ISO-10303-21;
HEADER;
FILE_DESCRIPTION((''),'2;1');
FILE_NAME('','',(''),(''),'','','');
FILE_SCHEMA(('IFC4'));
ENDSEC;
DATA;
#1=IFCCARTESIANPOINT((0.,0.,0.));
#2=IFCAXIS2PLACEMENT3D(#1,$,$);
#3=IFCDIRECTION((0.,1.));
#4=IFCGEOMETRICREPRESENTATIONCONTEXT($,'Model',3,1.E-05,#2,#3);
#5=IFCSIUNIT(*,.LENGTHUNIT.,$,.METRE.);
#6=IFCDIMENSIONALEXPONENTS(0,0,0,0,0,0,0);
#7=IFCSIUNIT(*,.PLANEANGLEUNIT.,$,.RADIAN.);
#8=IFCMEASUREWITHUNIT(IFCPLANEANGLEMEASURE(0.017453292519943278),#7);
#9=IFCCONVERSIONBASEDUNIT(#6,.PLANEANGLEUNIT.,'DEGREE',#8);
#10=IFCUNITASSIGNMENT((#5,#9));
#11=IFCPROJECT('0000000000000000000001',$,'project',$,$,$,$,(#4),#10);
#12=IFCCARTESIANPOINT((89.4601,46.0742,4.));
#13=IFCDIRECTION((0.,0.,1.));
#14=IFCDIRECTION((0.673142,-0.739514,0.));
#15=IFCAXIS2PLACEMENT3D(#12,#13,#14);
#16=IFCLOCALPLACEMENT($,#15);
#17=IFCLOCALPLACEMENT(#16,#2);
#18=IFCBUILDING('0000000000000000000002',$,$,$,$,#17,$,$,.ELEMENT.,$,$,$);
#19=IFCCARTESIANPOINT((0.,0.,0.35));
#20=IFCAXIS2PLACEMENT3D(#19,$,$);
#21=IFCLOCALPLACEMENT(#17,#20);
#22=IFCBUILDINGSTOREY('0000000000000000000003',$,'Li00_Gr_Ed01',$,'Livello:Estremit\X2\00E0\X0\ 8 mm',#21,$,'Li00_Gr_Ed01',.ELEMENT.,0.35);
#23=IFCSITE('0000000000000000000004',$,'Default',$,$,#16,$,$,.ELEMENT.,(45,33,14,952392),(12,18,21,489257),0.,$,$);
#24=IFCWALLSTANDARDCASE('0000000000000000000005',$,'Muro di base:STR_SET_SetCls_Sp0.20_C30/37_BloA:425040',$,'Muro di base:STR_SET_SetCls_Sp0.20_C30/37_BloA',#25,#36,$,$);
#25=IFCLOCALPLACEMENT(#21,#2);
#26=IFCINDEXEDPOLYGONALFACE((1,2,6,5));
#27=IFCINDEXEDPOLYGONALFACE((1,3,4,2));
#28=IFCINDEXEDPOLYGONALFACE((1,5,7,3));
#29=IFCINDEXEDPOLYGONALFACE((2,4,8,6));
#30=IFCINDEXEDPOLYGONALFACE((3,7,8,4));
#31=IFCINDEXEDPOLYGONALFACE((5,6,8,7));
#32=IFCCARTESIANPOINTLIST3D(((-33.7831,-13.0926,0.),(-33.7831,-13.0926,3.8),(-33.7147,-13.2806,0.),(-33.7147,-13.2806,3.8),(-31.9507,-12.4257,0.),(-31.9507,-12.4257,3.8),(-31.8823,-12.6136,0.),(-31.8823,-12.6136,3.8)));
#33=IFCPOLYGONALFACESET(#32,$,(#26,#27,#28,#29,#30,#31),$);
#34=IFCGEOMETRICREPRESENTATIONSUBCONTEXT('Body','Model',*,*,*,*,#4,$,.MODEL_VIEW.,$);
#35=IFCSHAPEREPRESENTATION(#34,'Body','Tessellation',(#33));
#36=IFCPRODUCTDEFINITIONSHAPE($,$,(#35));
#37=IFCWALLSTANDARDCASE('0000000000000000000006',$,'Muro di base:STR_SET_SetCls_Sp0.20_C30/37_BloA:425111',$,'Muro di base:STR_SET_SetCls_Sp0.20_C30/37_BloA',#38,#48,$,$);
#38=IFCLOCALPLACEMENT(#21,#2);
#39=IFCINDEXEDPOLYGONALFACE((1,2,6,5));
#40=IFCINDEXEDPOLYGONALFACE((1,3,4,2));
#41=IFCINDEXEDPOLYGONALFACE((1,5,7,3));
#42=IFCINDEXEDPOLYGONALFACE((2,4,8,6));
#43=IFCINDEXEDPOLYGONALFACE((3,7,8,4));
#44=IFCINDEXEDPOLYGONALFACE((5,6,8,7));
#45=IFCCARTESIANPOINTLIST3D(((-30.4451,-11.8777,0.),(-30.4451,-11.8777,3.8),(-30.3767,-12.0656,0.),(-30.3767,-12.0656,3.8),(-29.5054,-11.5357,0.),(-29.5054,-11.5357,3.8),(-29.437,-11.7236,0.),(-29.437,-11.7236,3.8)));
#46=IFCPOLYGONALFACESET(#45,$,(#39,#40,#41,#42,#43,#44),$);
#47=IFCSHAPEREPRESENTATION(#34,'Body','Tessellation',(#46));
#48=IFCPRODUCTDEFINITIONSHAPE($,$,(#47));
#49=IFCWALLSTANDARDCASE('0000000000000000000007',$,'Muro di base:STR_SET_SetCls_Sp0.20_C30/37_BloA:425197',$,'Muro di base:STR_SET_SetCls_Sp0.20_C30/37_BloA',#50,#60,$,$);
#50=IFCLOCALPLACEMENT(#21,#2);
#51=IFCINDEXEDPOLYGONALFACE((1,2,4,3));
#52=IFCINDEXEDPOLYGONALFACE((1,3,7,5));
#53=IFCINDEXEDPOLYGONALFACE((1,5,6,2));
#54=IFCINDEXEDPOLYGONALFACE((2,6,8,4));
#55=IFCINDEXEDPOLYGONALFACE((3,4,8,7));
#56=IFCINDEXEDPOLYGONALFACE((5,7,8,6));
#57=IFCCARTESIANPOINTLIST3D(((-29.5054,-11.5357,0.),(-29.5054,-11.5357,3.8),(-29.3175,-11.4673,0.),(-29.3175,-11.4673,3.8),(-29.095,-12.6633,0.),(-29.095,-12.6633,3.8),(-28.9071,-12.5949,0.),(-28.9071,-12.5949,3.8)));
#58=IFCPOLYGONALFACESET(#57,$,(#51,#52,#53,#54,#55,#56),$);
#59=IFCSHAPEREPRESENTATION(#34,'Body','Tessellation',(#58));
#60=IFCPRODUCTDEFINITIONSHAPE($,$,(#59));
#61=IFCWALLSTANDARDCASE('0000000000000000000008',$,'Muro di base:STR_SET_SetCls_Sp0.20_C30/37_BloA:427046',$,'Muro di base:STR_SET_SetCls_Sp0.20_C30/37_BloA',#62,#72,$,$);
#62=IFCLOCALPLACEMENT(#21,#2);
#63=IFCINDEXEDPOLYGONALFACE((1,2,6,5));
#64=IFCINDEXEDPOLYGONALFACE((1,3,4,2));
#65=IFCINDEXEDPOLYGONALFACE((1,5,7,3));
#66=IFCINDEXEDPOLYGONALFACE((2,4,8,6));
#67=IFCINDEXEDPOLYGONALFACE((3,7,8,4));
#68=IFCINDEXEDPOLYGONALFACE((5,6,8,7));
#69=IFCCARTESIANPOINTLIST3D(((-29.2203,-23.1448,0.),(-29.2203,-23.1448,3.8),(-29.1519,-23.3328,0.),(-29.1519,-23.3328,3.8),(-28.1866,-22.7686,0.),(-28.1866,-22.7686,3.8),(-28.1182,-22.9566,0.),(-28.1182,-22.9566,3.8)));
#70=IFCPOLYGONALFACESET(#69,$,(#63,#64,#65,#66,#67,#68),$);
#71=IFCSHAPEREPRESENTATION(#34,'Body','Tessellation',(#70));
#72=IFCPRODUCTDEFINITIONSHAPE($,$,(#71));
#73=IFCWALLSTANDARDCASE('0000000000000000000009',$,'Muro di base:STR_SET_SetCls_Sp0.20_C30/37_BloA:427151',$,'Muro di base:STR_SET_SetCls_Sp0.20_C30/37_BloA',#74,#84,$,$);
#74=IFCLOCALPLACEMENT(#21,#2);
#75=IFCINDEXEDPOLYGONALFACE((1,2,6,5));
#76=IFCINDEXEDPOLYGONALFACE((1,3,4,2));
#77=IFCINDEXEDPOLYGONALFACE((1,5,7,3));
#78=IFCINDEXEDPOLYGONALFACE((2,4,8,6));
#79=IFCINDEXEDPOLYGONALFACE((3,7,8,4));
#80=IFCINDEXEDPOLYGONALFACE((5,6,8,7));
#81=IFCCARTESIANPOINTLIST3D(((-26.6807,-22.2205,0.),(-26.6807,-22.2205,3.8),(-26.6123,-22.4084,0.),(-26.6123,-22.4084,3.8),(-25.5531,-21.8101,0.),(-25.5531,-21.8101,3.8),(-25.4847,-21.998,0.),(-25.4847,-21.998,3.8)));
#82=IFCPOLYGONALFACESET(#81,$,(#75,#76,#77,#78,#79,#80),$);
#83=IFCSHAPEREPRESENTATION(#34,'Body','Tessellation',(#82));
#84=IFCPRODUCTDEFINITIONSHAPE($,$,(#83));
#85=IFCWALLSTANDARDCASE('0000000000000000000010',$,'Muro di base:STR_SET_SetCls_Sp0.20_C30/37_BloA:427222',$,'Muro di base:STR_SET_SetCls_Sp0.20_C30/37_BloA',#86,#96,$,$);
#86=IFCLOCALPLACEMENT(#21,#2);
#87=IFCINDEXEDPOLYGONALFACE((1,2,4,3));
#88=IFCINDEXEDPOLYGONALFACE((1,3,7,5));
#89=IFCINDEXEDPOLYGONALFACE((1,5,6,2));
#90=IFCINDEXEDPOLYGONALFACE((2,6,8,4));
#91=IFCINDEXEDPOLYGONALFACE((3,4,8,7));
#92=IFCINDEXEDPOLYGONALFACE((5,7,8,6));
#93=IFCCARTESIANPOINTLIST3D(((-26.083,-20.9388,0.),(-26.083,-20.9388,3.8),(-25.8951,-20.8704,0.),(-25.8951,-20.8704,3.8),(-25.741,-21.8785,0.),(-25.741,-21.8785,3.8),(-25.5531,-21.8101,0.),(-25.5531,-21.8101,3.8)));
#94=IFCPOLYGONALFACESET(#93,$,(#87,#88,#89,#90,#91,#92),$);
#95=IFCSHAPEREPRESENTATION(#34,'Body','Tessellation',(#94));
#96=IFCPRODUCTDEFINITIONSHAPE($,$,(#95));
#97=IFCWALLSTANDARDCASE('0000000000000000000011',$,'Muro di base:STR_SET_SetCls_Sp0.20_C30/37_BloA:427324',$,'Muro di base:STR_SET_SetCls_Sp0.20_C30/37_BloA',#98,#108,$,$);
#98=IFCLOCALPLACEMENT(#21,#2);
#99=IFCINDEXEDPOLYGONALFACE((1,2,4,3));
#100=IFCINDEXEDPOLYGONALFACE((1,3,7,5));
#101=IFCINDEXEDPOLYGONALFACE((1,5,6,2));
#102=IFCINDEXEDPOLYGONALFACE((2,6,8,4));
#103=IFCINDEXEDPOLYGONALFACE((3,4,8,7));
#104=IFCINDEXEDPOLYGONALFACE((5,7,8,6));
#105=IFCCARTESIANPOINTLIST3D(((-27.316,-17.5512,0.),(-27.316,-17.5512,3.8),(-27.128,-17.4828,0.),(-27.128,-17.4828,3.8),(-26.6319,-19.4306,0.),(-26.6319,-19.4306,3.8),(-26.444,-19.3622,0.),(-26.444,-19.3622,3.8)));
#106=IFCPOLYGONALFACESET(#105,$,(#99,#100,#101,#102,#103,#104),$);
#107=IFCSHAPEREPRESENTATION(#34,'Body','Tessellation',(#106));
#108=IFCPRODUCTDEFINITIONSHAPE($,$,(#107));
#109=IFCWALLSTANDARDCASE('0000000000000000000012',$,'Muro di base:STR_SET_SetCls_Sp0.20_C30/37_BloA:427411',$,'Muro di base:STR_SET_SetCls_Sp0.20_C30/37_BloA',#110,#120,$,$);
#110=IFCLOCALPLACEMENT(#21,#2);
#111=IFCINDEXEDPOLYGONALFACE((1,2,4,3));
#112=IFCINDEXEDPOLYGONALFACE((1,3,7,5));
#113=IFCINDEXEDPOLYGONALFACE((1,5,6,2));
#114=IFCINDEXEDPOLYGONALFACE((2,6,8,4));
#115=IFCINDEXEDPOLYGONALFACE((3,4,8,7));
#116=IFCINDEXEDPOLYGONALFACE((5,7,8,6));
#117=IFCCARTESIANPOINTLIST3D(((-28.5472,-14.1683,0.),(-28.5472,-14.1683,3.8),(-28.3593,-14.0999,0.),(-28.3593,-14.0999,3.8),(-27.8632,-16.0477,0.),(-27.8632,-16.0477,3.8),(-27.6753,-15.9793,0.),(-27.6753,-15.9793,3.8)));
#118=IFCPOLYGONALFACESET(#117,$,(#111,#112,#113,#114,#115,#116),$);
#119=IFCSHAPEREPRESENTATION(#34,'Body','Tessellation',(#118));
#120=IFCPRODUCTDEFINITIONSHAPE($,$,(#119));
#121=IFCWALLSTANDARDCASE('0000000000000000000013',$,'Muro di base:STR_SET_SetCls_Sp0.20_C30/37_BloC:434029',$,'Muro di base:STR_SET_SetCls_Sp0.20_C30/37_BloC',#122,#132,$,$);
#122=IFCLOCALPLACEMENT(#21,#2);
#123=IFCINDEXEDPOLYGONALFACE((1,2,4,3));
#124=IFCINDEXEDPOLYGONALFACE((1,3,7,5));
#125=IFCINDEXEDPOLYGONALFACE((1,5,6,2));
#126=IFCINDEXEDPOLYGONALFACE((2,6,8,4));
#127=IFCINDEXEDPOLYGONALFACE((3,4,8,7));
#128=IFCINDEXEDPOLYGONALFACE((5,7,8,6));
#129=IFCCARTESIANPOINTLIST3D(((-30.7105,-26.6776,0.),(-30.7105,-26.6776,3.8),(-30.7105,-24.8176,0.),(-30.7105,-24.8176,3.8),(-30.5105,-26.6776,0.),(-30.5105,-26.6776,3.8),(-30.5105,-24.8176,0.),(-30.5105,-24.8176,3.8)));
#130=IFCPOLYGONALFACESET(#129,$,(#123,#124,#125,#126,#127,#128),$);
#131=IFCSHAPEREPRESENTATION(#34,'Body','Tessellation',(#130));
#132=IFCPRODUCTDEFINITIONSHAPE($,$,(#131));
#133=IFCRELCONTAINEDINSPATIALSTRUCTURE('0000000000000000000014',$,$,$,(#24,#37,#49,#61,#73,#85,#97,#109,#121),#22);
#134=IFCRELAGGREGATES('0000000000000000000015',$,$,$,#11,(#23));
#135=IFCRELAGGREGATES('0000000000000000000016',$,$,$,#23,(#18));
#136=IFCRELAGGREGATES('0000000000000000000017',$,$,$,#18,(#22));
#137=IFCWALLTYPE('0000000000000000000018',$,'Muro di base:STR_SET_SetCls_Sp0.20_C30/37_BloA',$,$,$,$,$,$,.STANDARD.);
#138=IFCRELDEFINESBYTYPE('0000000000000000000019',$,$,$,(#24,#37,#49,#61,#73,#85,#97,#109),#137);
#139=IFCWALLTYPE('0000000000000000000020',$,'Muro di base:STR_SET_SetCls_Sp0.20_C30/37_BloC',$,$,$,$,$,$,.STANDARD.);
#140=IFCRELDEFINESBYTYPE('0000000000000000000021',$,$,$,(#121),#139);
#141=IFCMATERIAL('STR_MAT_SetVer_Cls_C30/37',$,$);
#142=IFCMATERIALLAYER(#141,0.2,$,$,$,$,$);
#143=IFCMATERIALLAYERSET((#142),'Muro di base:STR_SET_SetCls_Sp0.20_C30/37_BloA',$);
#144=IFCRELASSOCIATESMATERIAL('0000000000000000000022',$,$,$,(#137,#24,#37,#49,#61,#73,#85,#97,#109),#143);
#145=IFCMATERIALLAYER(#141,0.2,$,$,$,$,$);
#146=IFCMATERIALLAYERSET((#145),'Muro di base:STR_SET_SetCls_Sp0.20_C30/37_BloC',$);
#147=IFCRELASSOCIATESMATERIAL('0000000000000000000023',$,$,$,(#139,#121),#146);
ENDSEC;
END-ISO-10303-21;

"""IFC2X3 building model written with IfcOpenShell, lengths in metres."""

from ifc_helpers import new_model, entity, si_unit, converted_unit, direction, frame, frame_2d, origin, place, context, subcontext, project, spatial, rectangle, extrude, material, layer, layer_set, layer_usage, type_object, element, save


model = new_model("IFC2X3")

# Units and contexts
model_context = context("Model", 3, precision=1e-05, world=origin(), true_north=direction((0.0, 1.0)))
body_context = subcontext(model_context, "Body", "Model", "MODEL_VIEW")
ifc_project = project(units=[si_unit("LENGTHUNIT", "METRE"), converted_unit("PLANEANGLEUNIT", "DEGREE", entity("IfcPlaneAngleMeasure", 0.017453292519943278), si_unit("PLANEANGLEUNIT", "RADIAN"), dimensions=[0, 0, 0, 0, 0, 0, 0])], contexts=[model_context])

# Site, building, storey
site_placement = place(None, frame((89.4601, 46.0742, 4.0), z_axis=(0.0, 0.0, 1.0), x_axis=(0.673142, -0.739514, 0.0)))
site = spatial("IfcSite", under=ifc_project, at=site_placement, Name="Default", CompositionType="ELEMENT", RefLatitude=(45, 33, 14, 952392), RefLongitude=(12, 18, 21, 489257), RefElevation=0.0)
building_placement = place(site_placement, origin())
building = spatial("IfcBuilding", under=site, at=building_placement, CompositionType="ELEMENT")
storey_placement = place(building_placement, frame((0.0, 0.0, 0.35)))
storey = spatial("IfcBuildingStorey", under=building, at=storey_placement, Name="Li00_Gr_Ed01", ObjectType="Livello:Estremità 8 mm", LongName="Li00_Gr_Ed01", CompositionType="ELEMENT", Elevation=0.35)

# Walls
ifc_material_1 = material(Name="STR_MAT_SetVer_Cls_C30/37")
ifc_layer_1 = layer(ifc_material_1, 0.2)
ifc_layer_set_1 = layer_set([ifc_layer_1], Name="Muro di base:STR_SET_SetCls_Sp0.20_C30/37_BloA")
ifc_layer_usage_1 = layer_usage(ifc_layer_set_1, "AXIS2", "NEGATIVE", 0.1)
wall_type_1 = type_object("IfcWallType", Name="Muro di base:STR_SET_SetCls_Sp0.20_C30/37_BloA", PredefinedType="STANDARD", material=ifc_layer_set_1)
wall_1_placement = place(storey_placement, frame((-33.7489, -13.1866, 0.0), z_axis=(0.0, 0.0, 1.0), x_axis=(0.939693, 0.34202, 0.0)))
element("IfcWallStandardCase", 1, at=wall_1_placement, inside=storey, type_object=wall_type_1, material=ifc_layer_usage_1, Name="Muro di base:STR_SET_SetCls_Sp0.20_C30/37_BloA:425040", ObjectType="Muro di base:STR_SET_SetCls_Sp0.20_C30/37_BloA", context=body_context, shape_type="SweptSolid", body=[
    extrude(rectangle(XDim=1.95, YDim=0.2, at=frame_2d((0.975, 0.0), x_axis=(-1.0, 0.0))), origin(), (0.0, 0.0, 1.0), 3.8),
])
wall_2_placement = place(storey_placement, frame((-30.4109, -11.9717, 0.0), z_axis=(0.0, 0.0, 1.0), x_axis=(0.939693, 0.34202, 0.0)))
element("IfcWallStandardCase", 2, at=wall_2_placement, inside=storey, type_object=wall_type_1, material=ifc_layer_usage_1, Name="Muro di base:STR_SET_SetCls_Sp0.20_C30/37_BloA:425111", ObjectType="Muro di base:STR_SET_SetCls_Sp0.20_C30/37_BloA", context=body_context, shape_type="SweptSolid", body=[
    extrude(rectangle(XDim=1.0, YDim=0.2, at=frame_2d((0.5, 0.0), x_axis=(-1.0, 0.0))), origin(), (0.0, 0.0, 1.0), 3.8),
])
wall_3_placement = place(storey_placement, frame((-29.4115, -11.5015, 0.0), z_axis=(0.0, 0.0, 1.0), x_axis=(0.34202, -0.939693, 0.0)))
element("IfcWallStandardCase", 3, at=wall_3_placement, inside=storey, type_object=wall_type_1, material=ifc_layer_usage_1, Name="Muro di base:STR_SET_SetCls_Sp0.20_C30/37_BloA:425197", ObjectType="Muro di base:STR_SET_SetCls_Sp0.20_C30/37_BloA", context=body_context, shape_type="SweptSolid", body=[
    extrude(rectangle(XDim=1.2, YDim=0.2, at=frame_2d((0.6, 0.0), x_axis=(-1.0, 0.0))), origin(), (0.0, 0.0, 1.0), 3.8),
])
wall_4_placement = place(storey_placement, frame((-29.1861, -23.2388, 0.0), z_axis=(0.0, 0.0, 1.0), x_axis=(0.939693, 0.34202, 0.0)))
element("IfcWallStandardCase", 4, at=wall_4_placement, inside=storey, type_object=wall_type_1, material=ifc_layer_usage_1, Name="Muro di base:STR_SET_SetCls_Sp0.20_C30/37_BloA:427046", ObjectType="Muro di base:STR_SET_SetCls_Sp0.20_C30/37_BloA", context=body_context, shape_type="SweptSolid", body=[
    extrude(rectangle(XDim=1.1, YDim=0.2, at=frame_2d((0.55, 0.0), x_axis=(-1.0, 0.0))), origin(), (0.0, 0.0, 1.0), 3.8),
])
wall_5_placement = place(storey_placement, frame((-26.6465, -22.3145, 0.0), z_axis=(0.0, 0.0, 1.0), x_axis=(0.939693, 0.34202, 0.0)))
element("IfcWallStandardCase", 5, at=wall_5_placement, inside=storey, type_object=wall_type_1, material=ifc_layer_usage_1, Name="Muro di base:STR_SET_SetCls_Sp0.20_C30/37_BloA:427151", ObjectType="Muro di base:STR_SET_SetCls_Sp0.20_C30/37_BloA", context=body_context, shape_type="SweptSolid", body=[
    extrude(rectangle(XDim=1.2, YDim=0.2, at=frame_2d((0.6, 0.0), x_axis=(-1.0, 0.0))), origin(), (0.0, 0.0, 1.0), 3.8),
])
wall_6_placement = place(storey_placement, frame((-25.647, -21.8443, 0.0), z_axis=(0.0, 0.0, 1.0), x_axis=(-0.34202, 0.939693, 0.0)))
element("IfcWallStandardCase", 6, at=wall_6_placement, inside=storey, type_object=wall_type_1, material=ifc_layer_usage_1, Name="Muro di base:STR_SET_SetCls_Sp0.20_C30/37_BloA:427222", ObjectType="Muro di base:STR_SET_SetCls_Sp0.20_C30/37_BloA", context=body_context, shape_type="SweptSolid", body=[
    extrude(rectangle(XDim=1.0, YDim=0.2, at=frame_2d((0.5, 0.0), x_axis=(-1.0, 0.0))), origin(), (0.0, 0.0, 1.0), 3.8),
])
for number, where, z_axis, x_axis, name in (
    (7, (-26.538, -19.3964, 0.0), (0.0, 0.0, 1.0), (-0.34202, 0.939693, 0.0), "Muro di base:STR_SET_SetCls_Sp0.20_C30/37_BloA:427324"),
    (8, (-27.7692, -16.0135, 0.0), (0.0, 0.0, 1.0), (-0.34202, 0.939693, 0.0), "Muro di base:STR_SET_SetCls_Sp0.20_C30/37_BloA:427411"),
):
    element("IfcWallStandardCase", number, at=place(storey_placement, frame(where, z_axis=z_axis, x_axis=x_axis)), inside=storey, type_object=wall_type_1, material=ifc_layer_usage_1, Name=name, ObjectType="Muro di base:STR_SET_SetCls_Sp0.20_C30/37_BloA", context=body_context, shape_type="SweptSolid", body=[
        extrude(rectangle(XDim=2.0, YDim=0.2, at=frame_2d((1.0, 0.0), x_axis=(-1.0, 0.0))), origin(), (0.0, 0.0, 1.0), 3.8),
    ])
ifc_layer_2 = layer(ifc_material_1, 0.2)
ifc_layer_set_2 = layer_set([ifc_layer_2], Name="Muro di base:STR_SET_SetCls_Sp0.20_C30/37_BloC")
ifc_layer_usage_2 = layer_usage(ifc_layer_set_2, "AXIS2", "NEGATIVE", 0.1)
wall_type_2 = type_object("IfcWallType", Name="Muro di base:STR_SET_SetCls_Sp0.20_C30/37_BloC", PredefinedType="STANDARD", material=ifc_layer_set_2)
wall_7_placement = place(storey_placement, frame((-30.6105, -24.8176, 0.0), z_axis=(0.0, 0.0, 1.0), x_axis=(0.0, -1.0, 0.0)))
element("IfcWallStandardCase", 9, at=wall_7_placement, inside=storey, type_object=wall_type_2, material=ifc_layer_usage_2, Name="Muro di base:STR_SET_SetCls_Sp0.20_C30/37_BloC:434029", ObjectType="Muro di base:STR_SET_SetCls_Sp0.20_C30/37_BloC", context=body_context, shape_type="SweptSolid", body=[
    extrude(rectangle(XDim=1.86, YDim=0.2, at=frame_2d((0.93, 0.0), x_axis=(-1.0, 0.0))), origin(), (0.0, 0.0, 1.0), 3.8),
])

save(model, "model.ifc")
